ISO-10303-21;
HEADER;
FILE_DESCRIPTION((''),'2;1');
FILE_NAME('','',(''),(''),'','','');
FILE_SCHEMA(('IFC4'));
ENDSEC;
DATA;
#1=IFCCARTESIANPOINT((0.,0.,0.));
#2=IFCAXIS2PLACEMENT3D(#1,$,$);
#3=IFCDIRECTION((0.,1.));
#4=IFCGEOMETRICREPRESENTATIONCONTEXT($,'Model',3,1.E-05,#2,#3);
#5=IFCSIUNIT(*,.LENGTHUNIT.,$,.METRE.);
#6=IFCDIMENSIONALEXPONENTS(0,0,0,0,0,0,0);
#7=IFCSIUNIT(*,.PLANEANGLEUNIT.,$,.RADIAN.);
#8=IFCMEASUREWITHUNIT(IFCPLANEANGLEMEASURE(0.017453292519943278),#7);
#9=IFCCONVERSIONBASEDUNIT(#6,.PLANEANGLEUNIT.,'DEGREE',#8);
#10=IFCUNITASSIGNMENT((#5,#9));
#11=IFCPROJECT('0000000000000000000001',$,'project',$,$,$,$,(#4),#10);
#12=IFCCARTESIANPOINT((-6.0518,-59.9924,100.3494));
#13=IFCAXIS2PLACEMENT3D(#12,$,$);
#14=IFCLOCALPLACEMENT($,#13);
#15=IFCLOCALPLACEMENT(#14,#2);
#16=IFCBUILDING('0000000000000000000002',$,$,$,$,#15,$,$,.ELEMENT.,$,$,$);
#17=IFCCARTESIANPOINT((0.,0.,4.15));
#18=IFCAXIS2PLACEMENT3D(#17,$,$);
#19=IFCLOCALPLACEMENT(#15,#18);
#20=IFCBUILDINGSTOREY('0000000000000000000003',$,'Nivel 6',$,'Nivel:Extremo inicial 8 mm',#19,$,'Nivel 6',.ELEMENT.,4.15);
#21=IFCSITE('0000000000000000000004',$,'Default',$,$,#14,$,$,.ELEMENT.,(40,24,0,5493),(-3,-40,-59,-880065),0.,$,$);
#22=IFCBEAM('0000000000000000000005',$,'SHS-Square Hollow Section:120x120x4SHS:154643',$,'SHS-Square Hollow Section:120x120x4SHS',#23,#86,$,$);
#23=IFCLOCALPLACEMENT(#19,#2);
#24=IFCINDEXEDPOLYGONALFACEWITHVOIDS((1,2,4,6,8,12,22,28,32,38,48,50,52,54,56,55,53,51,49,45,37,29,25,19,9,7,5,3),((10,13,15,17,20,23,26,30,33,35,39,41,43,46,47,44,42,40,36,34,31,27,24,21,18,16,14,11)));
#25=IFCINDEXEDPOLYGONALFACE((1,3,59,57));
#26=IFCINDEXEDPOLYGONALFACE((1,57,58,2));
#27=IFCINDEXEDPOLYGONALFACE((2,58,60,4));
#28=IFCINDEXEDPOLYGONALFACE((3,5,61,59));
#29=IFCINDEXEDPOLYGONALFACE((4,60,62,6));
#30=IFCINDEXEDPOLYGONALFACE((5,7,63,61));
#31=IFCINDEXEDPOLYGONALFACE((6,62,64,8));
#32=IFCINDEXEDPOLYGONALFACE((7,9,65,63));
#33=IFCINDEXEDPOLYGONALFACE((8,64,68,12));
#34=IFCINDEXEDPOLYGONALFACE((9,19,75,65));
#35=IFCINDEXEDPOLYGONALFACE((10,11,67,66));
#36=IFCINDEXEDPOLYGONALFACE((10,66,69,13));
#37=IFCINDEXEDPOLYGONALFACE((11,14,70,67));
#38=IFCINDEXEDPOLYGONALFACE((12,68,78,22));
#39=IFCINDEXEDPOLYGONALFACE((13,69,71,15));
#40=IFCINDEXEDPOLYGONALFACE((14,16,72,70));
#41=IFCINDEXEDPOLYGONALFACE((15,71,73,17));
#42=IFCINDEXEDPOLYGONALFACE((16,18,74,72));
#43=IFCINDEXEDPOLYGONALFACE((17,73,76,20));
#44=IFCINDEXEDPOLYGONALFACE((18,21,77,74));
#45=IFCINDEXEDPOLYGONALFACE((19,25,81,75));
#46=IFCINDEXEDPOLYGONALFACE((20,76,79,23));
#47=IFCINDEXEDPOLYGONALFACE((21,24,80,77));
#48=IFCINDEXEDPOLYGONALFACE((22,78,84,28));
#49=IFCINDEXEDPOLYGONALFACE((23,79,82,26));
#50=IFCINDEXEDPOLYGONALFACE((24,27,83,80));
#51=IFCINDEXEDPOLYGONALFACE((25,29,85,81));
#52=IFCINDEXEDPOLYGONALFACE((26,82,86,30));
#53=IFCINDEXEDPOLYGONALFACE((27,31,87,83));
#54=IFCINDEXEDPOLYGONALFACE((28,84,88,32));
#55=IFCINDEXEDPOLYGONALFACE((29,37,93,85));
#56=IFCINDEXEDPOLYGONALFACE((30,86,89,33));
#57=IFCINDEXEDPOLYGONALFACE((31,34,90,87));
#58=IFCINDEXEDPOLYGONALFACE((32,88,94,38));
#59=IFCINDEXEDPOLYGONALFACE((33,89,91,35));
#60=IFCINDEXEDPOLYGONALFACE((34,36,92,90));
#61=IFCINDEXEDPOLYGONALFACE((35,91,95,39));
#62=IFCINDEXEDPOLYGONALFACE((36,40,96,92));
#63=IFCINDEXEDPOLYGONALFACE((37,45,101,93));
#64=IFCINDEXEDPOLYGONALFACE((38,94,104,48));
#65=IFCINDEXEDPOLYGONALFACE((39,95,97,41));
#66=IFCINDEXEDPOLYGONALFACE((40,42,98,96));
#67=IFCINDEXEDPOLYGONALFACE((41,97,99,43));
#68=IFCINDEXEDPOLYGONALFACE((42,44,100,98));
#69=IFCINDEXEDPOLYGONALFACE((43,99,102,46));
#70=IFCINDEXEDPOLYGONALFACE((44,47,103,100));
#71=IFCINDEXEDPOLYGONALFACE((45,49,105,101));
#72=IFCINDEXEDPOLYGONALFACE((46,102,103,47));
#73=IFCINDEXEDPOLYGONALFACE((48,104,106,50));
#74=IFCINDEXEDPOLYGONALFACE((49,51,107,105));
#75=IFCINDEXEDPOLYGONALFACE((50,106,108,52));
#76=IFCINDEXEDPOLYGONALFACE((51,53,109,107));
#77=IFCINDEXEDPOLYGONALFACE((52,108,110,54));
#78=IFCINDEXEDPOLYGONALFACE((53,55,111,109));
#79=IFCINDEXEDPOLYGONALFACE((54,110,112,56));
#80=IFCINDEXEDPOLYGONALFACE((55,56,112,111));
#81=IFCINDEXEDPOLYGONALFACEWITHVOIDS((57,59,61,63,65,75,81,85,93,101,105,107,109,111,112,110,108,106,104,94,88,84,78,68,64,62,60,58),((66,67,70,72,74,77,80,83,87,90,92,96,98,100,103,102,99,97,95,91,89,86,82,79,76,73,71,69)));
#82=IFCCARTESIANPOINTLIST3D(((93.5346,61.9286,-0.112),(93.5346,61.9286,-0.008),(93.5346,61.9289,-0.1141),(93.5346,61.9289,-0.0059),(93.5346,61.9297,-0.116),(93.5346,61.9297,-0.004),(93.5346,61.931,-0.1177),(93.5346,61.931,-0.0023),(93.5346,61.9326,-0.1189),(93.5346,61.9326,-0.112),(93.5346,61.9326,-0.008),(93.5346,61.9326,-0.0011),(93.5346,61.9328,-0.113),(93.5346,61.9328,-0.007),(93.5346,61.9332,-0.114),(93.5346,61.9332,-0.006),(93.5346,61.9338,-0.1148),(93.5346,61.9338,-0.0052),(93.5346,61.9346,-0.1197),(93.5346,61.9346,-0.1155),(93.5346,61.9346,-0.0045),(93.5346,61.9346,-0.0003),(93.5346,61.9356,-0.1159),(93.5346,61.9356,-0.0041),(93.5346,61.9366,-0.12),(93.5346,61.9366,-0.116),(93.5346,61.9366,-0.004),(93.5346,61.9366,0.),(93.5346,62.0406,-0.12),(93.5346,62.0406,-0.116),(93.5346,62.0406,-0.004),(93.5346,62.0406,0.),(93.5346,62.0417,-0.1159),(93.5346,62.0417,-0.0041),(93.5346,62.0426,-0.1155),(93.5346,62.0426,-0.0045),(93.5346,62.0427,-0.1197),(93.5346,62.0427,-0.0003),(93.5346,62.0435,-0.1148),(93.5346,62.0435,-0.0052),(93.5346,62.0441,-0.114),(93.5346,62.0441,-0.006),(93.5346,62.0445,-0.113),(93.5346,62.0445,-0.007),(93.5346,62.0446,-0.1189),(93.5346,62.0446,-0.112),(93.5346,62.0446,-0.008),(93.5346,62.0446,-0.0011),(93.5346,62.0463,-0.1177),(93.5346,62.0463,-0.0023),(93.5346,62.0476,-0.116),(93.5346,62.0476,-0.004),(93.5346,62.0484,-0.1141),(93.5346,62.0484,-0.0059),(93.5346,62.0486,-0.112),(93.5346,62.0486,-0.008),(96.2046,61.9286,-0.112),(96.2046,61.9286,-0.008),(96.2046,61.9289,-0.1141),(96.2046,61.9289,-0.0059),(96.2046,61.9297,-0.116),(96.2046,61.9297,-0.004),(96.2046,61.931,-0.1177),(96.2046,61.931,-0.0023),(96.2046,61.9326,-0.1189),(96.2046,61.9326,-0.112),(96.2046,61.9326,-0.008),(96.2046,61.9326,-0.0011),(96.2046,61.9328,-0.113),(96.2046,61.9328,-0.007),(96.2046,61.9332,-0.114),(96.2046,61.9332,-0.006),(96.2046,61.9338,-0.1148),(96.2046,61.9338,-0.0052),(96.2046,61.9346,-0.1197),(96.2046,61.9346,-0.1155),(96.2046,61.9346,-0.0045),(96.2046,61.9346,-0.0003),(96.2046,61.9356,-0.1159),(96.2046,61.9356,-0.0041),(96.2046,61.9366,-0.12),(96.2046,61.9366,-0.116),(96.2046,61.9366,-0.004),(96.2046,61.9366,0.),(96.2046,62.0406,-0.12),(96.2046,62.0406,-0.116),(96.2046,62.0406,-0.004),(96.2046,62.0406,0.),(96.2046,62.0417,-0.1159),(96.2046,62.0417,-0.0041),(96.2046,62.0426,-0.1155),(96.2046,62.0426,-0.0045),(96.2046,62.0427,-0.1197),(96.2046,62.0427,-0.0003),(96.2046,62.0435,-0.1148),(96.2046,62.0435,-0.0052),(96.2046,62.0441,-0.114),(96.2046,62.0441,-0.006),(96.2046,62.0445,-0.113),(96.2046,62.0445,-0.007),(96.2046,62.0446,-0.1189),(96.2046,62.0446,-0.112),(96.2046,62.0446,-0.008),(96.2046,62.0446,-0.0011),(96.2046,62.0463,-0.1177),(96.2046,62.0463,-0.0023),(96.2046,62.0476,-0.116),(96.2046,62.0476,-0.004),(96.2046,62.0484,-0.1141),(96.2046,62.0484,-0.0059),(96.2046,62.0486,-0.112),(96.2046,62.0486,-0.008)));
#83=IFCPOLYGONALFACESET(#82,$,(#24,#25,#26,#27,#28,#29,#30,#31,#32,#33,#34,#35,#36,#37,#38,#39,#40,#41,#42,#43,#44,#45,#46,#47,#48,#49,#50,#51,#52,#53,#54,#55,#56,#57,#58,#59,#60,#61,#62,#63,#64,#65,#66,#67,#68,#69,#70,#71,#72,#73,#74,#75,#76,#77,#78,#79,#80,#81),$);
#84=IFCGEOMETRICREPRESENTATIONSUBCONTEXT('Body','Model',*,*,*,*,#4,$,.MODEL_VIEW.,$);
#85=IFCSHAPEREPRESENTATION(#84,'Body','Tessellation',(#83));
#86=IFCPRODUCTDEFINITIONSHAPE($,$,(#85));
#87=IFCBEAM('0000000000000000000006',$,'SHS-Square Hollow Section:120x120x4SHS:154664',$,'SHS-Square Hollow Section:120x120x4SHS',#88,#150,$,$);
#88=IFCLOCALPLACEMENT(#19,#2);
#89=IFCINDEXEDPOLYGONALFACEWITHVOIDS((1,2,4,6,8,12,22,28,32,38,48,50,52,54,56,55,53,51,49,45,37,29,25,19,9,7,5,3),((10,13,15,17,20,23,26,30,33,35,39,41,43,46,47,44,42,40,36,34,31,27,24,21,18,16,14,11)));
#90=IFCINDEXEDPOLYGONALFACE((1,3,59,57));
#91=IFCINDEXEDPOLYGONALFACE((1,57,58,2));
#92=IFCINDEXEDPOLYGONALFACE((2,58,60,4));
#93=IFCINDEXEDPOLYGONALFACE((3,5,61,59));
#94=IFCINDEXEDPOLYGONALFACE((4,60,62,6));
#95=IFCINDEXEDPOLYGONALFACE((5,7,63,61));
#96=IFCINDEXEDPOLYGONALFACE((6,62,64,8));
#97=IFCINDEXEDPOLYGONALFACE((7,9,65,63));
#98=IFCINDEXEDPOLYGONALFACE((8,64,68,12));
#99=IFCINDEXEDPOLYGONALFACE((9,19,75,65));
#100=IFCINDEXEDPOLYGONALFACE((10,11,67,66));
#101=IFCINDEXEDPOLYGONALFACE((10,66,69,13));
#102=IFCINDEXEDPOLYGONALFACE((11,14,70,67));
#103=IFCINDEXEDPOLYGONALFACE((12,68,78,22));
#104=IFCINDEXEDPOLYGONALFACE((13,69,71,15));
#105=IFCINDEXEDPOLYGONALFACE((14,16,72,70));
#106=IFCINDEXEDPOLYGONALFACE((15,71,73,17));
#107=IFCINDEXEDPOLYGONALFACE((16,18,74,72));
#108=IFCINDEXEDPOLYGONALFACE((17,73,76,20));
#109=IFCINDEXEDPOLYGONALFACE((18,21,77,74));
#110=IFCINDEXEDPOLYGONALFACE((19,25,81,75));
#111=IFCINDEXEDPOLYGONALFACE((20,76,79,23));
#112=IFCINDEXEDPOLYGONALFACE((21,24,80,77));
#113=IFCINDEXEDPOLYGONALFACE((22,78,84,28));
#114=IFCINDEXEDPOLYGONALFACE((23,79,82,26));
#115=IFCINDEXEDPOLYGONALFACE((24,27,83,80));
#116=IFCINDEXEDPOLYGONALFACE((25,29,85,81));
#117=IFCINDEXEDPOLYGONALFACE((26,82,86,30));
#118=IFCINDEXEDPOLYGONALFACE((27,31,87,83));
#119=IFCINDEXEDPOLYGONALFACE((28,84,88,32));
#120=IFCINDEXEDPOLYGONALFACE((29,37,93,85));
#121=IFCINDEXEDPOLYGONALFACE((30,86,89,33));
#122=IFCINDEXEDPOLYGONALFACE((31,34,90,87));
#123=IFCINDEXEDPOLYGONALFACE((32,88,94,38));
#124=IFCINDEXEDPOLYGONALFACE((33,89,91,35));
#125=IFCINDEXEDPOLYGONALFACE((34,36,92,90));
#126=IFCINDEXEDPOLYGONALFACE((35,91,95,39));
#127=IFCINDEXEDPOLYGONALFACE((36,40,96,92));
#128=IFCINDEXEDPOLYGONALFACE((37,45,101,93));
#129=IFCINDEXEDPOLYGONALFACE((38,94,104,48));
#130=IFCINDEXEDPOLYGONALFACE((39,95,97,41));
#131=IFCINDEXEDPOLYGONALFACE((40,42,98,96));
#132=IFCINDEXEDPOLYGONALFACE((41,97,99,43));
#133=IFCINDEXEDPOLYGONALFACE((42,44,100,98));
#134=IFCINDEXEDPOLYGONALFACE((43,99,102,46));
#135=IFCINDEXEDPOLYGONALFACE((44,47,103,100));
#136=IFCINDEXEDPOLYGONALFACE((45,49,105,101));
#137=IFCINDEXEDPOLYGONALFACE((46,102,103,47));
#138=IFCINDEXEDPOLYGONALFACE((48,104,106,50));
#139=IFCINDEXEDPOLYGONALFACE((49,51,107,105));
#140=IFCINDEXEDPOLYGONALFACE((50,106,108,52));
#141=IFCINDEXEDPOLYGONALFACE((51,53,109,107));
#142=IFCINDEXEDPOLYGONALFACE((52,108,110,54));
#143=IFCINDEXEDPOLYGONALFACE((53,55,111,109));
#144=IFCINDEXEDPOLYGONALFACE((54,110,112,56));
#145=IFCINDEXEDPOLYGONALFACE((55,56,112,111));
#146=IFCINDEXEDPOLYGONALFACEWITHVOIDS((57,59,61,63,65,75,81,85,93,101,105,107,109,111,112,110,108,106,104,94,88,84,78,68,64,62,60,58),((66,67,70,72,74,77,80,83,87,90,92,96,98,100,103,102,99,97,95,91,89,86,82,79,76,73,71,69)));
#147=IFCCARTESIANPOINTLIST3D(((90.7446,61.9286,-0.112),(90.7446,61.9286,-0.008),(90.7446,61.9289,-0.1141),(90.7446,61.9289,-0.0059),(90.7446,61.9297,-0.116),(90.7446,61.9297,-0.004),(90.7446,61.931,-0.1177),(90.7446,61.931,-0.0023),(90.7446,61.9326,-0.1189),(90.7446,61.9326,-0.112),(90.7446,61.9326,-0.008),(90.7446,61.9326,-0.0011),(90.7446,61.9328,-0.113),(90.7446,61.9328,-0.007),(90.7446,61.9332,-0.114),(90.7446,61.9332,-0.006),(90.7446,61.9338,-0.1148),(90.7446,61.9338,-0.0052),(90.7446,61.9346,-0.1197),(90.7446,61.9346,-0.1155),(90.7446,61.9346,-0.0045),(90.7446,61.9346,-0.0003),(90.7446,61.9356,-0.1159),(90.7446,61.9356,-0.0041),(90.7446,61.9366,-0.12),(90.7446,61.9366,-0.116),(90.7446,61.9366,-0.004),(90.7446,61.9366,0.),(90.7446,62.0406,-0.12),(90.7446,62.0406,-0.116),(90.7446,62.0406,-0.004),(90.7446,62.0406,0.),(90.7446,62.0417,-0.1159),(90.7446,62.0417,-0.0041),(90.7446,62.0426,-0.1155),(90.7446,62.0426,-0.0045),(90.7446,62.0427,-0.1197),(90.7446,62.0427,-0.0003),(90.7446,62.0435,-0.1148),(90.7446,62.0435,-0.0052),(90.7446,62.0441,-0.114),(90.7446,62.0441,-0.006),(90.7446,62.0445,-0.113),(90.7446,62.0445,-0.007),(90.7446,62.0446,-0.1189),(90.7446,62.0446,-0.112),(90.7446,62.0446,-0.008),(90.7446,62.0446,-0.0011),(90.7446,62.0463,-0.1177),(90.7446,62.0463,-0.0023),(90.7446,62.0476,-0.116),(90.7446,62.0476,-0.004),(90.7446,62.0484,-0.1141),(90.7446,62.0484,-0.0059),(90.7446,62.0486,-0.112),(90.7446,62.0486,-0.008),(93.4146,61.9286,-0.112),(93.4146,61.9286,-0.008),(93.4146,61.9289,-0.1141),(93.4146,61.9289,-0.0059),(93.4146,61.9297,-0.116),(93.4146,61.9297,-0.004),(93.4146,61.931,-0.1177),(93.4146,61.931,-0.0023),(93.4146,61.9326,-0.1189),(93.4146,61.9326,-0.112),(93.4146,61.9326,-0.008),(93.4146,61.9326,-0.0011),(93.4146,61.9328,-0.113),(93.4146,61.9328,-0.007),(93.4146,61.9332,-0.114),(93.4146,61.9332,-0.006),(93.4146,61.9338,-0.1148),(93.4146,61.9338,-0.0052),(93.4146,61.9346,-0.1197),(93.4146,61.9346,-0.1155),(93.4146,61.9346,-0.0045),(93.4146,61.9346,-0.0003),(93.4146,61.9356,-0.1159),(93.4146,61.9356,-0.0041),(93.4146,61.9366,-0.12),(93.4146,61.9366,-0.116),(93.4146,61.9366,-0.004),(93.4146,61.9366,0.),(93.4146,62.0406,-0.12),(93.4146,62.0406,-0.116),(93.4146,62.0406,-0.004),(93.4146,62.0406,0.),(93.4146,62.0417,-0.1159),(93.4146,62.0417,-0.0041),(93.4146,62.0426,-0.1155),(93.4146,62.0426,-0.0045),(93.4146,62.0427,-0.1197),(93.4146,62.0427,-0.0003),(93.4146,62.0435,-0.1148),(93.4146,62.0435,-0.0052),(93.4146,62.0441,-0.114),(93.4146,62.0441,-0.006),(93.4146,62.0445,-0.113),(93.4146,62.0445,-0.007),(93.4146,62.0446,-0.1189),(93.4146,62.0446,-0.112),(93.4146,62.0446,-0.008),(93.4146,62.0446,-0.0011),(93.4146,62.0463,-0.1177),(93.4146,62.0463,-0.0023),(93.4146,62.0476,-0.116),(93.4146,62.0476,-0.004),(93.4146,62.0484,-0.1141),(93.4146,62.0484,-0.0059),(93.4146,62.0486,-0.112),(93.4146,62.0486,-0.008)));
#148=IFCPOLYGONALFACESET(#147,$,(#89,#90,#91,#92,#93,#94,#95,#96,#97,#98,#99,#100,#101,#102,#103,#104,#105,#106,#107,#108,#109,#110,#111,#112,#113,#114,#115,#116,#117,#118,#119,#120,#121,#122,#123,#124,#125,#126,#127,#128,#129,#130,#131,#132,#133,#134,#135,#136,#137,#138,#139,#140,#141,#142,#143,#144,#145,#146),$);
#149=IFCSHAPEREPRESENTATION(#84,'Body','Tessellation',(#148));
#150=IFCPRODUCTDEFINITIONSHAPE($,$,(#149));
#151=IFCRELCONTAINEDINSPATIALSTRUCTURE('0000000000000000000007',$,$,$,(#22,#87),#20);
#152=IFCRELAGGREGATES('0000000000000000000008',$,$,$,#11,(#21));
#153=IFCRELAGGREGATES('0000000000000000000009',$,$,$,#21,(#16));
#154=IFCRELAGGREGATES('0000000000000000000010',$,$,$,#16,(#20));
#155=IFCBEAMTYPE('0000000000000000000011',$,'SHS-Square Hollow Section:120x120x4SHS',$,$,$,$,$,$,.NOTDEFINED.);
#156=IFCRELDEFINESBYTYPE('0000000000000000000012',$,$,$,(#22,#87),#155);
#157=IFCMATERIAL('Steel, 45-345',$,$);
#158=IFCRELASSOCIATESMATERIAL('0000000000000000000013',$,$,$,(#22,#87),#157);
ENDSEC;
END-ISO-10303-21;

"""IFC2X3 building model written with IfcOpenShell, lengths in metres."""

from ifc_helpers import new_model, entity, si_unit, converted_unit, direction, frame, frame_2d, origin, place, context, subcontext, project, spatial, polyline, circle_curve, parameter, trimmed, segment, composite_curve, outline, extrude, material, type_object, element, save


model = new_model("IFC2X3")

# Units and contexts
model_context = context("Model", 3, precision=1e-05, world=origin(), true_north=direction((0.0, 1.0)))
body_context = subcontext(model_context, "Body", "Model", "MODEL_VIEW")
ifc_project = project(units=[si_unit("LENGTHUNIT", "METRE"), converted_unit("PLANEANGLEUNIT", "DEGREE", entity("IfcPlaneAngleMeasure", 0.017453292519943278), si_unit("PLANEANGLEUNIT", "RADIAN"), dimensions=[0, 0, 0, 0, 0, 0, 0])], contexts=[model_context])

# Site, building, storey
site_placement = place(None, frame((-6.0518, -59.9924, 100.3494)))
site = spatial("IfcSite", under=ifc_project, at=site_placement, Name="Default", CompositionType="ELEMENT", RefLatitude=(40, 24, 0, 5493), RefLongitude=(-3, -40, -59, -880065), RefElevation=0.0)
building_placement = place(site_placement, origin())
building = spatial("IfcBuilding", under=site, at=building_placement, CompositionType="ELEMENT")
storey_placement = place(building_placement, frame((0.0, 0.0, 4.15)))
storey = spatial("IfcBuildingStorey", under=building, at=storey_placement, Name="Nivel 6", ObjectType="Nivel:Extremo inicial 8 mm", LongName="Nivel 6", CompositionType="ELEMENT", Elevation=4.15)

# Beams
ifc_material_1 = material(Name="Steel, 45-345")
beam_type = type_object("IfcBeamType", Name="SHS-Square Hollow Section:120x120x4SHS", PredefinedType="NOTDEFINED")
beam_1_placement = place(storey_placement, frame((96.2646, 61.9886, 0.0), z_axis=(0.0, 0.0, 1.0), x_axis=(-1.0, 0.0, 0.0)))
element("IfcBeam", 1, at=beam_1_placement, inside=storey, type_object=beam_type, material=ifc_material_1, Name="SHS-Square Hollow Section:120x120x4SHS:154643", ObjectType="SHS-Square Hollow Section:120x120x4SHS", context=body_context, shape_type="SweptSolid", body=[
    extrude(outline(composite_curve([segment(trimmed(circle_curve(frame_2d((-0.052, -0.052), x_axis=(1.0, 0.0)), 0.008), [parameter(180.0)], [parameter(270.0)], True, "PARAMETER"), True, "CONTINUOUS"), segment(polyline([(-0.052, -0.06), (0.052, -0.06)]), True, "CONTINUOUS"), segment(trimmed(circle_curve(frame_2d((0.052, -0.052), x_axis=(1.0, 0.0)), 0.008), [parameter(270.0)], [parameter(0.0)], True, "PARAMETER"), True, "CONTINUOUS"), segment(polyline([(0.06, -0.052), (0.06, 0.052)]), True, "CONTINUOUS"), segment(trimmed(circle_curve(frame_2d((0.052, 0.052), x_axis=(1.0, 0.0)), 0.008), [parameter(360.0)], [parameter(90.0)], True, "PARAMETER"), True, "CONTINUOUS"), segment(polyline([(0.052, 0.06), (-0.052, 0.06)]), True, "CONTINUOUS"), segment(trimmed(circle_curve(frame_2d((-0.052, 0.052), x_axis=(1.0, 0.0)), 0.008), [parameter(90.0)], [parameter(180.0)], True, "PARAMETER"), True, "CONTINUOUS"), segment(polyline([(-0.06, 0.052), (-0.06, -0.052)]), True, "CONTINUOUS")], self_intersect=False), holes=[composite_curve([segment(polyline([(0.052, -0.056), (-0.052, -0.056)]), True, "CONTINUOUS"), segment(trimmed(circle_curve(frame_2d((-0.052, -0.052), x_axis=(1.0, 0.0)), 0.004), [parameter(180.0)], [parameter(270.0)], True, "PARAMETER"), False, "CONTINUOUS"), segment(polyline([(-0.056, -0.052), (-0.056, 0.052)]), True, "CONTINUOUS"), segment(trimmed(circle_curve(frame_2d((-0.052, 0.052), x_axis=(1.0, 0.0)), 0.004), [parameter(90.0)], [parameter(180.0)], True, "PARAMETER"), False, "CONTINUOUS"), segment(polyline([(-0.052, 0.056), (0.052, 0.056)]), True, "CONTINUOUS"), segment(trimmed(circle_curve(frame_2d((0.052, 0.052), x_axis=(1.0, 0.0)), 0.004), [parameter(0.0)], [parameter(90.0)], True, "PARAMETER"), False, "CONTINUOUS"), segment(polyline([(0.056, 0.052), (0.056, -0.052)]), True, "CONTINUOUS"), segment(trimmed(circle_curve(frame_2d((0.052, -0.052), x_axis=(1.0, 0.0)), 0.004), [parameter(270.0)], [parameter(0.0)], True, "PARAMETER"), False, "CONTINUOUS")], self_intersect=False)]), frame((0.06, 0.0, -0.06), z_axis=(1.0, 0.0, 0.0), x_axis=(0.0, -1.0, 0.0)), (0.0, 0.0, 1.0), 2.67),
])
beam_2_placement = place(storey_placement, frame((93.4746, 61.9886, 0.0), z_axis=(0.0, 0.0, 1.0), x_axis=(-1.0, 0.0, 0.0)))
element("IfcBeam", 2, at=beam_2_placement, inside=storey, type_object=beam_type, material=ifc_material_1, Name="SHS-Square Hollow Section:120x120x4SHS:154664", ObjectType="SHS-Square Hollow Section:120x120x4SHS", context=body_context, shape_type="SweptSolid", body=[
    extrude(outline(composite_curve([segment(trimmed(circle_curve(frame_2d((-0.052, -0.052), x_axis=(1.0, 0.0)), 0.008), [parameter(180.0)], [parameter(270.0)], True, "PARAMETER"), True, "CONTINUOUS"), segment(polyline([(-0.052, -0.06), (0.052, -0.06)]), True, "CONTINUOUS"), segment(trimmed(circle_curve(frame_2d((0.052, -0.052), x_axis=(1.0, 0.0)), 0.008), [parameter(270.0)], [parameter(0.0)], True, "PARAMETER"), True, "CONTINUOUS"), segment(polyline([(0.06, -0.052), (0.06, 0.052)]), True, "CONTINUOUS"), segment(trimmed(circle_curve(frame_2d((0.052, 0.052), x_axis=(1.0, 0.0)), 0.008), [parameter(360.0)], [parameter(90.0)], True, "PARAMETER"), True, "CONTINUOUS"), segment(polyline([(0.052, 0.06), (-0.052, 0.06)]), True, "CONTINUOUS"), segment(trimmed(circle_curve(frame_2d((-0.052, 0.052), x_axis=(1.0, 0.0)), 0.008), [parameter(90.0)], [parameter(180.0)], True, "PARAMETER"), True, "CONTINUOUS"), segment(polyline([(-0.06, 0.052), (-0.06, -0.052)]), True, "CONTINUOUS")], self_intersect=False), holes=[composite_curve([segment(polyline([(0.052, -0.056), (-0.052, -0.056)]), True, "CONTINUOUS"), segment(trimmed(circle_curve(frame_2d((-0.052, -0.052), x_axis=(1.0, 0.0)), 0.004), [parameter(180.0)], [parameter(270.0)], True, "PARAMETER"), False, "CONTINUOUS"), segment(polyline([(-0.056, -0.052), (-0.056, 0.052)]), True, "CONTINUOUS"), segment(trimmed(circle_curve(frame_2d((-0.052, 0.052), x_axis=(1.0, 0.0)), 0.004), [parameter(90.0)], [parameter(180.0)], True, "PARAMETER"), False, "CONTINUOUS"), segment(polyline([(-0.052, 0.056), (0.052, 0.056)]), True, "CONTINUOUS"), segment(trimmed(circle_curve(frame_2d((0.052, 0.052), x_axis=(1.0, 0.0)), 0.004), [parameter(0.0)], [parameter(90.0)], True, "PARAMETER"), False, "CONTINUOUS"), segment(polyline([(0.056, 0.052), (0.056, -0.052)]), True, "CONTINUOUS"), segment(trimmed(circle_curve(frame_2d((0.052, -0.052), x_axis=(1.0, 0.0)), 0.004), [parameter(270.0)], [parameter(0.0)], True, "PARAMETER"), False, "CONTINUOUS")], self_intersect=False)]), frame((0.06, 0.0, -0.06), z_axis=(1.0, 0.0, 0.0), x_axis=(0.0, -1.0, 0.0)), (0.0, 0.0, 1.0), 2.67),
])

save(model, "model.ifc")
